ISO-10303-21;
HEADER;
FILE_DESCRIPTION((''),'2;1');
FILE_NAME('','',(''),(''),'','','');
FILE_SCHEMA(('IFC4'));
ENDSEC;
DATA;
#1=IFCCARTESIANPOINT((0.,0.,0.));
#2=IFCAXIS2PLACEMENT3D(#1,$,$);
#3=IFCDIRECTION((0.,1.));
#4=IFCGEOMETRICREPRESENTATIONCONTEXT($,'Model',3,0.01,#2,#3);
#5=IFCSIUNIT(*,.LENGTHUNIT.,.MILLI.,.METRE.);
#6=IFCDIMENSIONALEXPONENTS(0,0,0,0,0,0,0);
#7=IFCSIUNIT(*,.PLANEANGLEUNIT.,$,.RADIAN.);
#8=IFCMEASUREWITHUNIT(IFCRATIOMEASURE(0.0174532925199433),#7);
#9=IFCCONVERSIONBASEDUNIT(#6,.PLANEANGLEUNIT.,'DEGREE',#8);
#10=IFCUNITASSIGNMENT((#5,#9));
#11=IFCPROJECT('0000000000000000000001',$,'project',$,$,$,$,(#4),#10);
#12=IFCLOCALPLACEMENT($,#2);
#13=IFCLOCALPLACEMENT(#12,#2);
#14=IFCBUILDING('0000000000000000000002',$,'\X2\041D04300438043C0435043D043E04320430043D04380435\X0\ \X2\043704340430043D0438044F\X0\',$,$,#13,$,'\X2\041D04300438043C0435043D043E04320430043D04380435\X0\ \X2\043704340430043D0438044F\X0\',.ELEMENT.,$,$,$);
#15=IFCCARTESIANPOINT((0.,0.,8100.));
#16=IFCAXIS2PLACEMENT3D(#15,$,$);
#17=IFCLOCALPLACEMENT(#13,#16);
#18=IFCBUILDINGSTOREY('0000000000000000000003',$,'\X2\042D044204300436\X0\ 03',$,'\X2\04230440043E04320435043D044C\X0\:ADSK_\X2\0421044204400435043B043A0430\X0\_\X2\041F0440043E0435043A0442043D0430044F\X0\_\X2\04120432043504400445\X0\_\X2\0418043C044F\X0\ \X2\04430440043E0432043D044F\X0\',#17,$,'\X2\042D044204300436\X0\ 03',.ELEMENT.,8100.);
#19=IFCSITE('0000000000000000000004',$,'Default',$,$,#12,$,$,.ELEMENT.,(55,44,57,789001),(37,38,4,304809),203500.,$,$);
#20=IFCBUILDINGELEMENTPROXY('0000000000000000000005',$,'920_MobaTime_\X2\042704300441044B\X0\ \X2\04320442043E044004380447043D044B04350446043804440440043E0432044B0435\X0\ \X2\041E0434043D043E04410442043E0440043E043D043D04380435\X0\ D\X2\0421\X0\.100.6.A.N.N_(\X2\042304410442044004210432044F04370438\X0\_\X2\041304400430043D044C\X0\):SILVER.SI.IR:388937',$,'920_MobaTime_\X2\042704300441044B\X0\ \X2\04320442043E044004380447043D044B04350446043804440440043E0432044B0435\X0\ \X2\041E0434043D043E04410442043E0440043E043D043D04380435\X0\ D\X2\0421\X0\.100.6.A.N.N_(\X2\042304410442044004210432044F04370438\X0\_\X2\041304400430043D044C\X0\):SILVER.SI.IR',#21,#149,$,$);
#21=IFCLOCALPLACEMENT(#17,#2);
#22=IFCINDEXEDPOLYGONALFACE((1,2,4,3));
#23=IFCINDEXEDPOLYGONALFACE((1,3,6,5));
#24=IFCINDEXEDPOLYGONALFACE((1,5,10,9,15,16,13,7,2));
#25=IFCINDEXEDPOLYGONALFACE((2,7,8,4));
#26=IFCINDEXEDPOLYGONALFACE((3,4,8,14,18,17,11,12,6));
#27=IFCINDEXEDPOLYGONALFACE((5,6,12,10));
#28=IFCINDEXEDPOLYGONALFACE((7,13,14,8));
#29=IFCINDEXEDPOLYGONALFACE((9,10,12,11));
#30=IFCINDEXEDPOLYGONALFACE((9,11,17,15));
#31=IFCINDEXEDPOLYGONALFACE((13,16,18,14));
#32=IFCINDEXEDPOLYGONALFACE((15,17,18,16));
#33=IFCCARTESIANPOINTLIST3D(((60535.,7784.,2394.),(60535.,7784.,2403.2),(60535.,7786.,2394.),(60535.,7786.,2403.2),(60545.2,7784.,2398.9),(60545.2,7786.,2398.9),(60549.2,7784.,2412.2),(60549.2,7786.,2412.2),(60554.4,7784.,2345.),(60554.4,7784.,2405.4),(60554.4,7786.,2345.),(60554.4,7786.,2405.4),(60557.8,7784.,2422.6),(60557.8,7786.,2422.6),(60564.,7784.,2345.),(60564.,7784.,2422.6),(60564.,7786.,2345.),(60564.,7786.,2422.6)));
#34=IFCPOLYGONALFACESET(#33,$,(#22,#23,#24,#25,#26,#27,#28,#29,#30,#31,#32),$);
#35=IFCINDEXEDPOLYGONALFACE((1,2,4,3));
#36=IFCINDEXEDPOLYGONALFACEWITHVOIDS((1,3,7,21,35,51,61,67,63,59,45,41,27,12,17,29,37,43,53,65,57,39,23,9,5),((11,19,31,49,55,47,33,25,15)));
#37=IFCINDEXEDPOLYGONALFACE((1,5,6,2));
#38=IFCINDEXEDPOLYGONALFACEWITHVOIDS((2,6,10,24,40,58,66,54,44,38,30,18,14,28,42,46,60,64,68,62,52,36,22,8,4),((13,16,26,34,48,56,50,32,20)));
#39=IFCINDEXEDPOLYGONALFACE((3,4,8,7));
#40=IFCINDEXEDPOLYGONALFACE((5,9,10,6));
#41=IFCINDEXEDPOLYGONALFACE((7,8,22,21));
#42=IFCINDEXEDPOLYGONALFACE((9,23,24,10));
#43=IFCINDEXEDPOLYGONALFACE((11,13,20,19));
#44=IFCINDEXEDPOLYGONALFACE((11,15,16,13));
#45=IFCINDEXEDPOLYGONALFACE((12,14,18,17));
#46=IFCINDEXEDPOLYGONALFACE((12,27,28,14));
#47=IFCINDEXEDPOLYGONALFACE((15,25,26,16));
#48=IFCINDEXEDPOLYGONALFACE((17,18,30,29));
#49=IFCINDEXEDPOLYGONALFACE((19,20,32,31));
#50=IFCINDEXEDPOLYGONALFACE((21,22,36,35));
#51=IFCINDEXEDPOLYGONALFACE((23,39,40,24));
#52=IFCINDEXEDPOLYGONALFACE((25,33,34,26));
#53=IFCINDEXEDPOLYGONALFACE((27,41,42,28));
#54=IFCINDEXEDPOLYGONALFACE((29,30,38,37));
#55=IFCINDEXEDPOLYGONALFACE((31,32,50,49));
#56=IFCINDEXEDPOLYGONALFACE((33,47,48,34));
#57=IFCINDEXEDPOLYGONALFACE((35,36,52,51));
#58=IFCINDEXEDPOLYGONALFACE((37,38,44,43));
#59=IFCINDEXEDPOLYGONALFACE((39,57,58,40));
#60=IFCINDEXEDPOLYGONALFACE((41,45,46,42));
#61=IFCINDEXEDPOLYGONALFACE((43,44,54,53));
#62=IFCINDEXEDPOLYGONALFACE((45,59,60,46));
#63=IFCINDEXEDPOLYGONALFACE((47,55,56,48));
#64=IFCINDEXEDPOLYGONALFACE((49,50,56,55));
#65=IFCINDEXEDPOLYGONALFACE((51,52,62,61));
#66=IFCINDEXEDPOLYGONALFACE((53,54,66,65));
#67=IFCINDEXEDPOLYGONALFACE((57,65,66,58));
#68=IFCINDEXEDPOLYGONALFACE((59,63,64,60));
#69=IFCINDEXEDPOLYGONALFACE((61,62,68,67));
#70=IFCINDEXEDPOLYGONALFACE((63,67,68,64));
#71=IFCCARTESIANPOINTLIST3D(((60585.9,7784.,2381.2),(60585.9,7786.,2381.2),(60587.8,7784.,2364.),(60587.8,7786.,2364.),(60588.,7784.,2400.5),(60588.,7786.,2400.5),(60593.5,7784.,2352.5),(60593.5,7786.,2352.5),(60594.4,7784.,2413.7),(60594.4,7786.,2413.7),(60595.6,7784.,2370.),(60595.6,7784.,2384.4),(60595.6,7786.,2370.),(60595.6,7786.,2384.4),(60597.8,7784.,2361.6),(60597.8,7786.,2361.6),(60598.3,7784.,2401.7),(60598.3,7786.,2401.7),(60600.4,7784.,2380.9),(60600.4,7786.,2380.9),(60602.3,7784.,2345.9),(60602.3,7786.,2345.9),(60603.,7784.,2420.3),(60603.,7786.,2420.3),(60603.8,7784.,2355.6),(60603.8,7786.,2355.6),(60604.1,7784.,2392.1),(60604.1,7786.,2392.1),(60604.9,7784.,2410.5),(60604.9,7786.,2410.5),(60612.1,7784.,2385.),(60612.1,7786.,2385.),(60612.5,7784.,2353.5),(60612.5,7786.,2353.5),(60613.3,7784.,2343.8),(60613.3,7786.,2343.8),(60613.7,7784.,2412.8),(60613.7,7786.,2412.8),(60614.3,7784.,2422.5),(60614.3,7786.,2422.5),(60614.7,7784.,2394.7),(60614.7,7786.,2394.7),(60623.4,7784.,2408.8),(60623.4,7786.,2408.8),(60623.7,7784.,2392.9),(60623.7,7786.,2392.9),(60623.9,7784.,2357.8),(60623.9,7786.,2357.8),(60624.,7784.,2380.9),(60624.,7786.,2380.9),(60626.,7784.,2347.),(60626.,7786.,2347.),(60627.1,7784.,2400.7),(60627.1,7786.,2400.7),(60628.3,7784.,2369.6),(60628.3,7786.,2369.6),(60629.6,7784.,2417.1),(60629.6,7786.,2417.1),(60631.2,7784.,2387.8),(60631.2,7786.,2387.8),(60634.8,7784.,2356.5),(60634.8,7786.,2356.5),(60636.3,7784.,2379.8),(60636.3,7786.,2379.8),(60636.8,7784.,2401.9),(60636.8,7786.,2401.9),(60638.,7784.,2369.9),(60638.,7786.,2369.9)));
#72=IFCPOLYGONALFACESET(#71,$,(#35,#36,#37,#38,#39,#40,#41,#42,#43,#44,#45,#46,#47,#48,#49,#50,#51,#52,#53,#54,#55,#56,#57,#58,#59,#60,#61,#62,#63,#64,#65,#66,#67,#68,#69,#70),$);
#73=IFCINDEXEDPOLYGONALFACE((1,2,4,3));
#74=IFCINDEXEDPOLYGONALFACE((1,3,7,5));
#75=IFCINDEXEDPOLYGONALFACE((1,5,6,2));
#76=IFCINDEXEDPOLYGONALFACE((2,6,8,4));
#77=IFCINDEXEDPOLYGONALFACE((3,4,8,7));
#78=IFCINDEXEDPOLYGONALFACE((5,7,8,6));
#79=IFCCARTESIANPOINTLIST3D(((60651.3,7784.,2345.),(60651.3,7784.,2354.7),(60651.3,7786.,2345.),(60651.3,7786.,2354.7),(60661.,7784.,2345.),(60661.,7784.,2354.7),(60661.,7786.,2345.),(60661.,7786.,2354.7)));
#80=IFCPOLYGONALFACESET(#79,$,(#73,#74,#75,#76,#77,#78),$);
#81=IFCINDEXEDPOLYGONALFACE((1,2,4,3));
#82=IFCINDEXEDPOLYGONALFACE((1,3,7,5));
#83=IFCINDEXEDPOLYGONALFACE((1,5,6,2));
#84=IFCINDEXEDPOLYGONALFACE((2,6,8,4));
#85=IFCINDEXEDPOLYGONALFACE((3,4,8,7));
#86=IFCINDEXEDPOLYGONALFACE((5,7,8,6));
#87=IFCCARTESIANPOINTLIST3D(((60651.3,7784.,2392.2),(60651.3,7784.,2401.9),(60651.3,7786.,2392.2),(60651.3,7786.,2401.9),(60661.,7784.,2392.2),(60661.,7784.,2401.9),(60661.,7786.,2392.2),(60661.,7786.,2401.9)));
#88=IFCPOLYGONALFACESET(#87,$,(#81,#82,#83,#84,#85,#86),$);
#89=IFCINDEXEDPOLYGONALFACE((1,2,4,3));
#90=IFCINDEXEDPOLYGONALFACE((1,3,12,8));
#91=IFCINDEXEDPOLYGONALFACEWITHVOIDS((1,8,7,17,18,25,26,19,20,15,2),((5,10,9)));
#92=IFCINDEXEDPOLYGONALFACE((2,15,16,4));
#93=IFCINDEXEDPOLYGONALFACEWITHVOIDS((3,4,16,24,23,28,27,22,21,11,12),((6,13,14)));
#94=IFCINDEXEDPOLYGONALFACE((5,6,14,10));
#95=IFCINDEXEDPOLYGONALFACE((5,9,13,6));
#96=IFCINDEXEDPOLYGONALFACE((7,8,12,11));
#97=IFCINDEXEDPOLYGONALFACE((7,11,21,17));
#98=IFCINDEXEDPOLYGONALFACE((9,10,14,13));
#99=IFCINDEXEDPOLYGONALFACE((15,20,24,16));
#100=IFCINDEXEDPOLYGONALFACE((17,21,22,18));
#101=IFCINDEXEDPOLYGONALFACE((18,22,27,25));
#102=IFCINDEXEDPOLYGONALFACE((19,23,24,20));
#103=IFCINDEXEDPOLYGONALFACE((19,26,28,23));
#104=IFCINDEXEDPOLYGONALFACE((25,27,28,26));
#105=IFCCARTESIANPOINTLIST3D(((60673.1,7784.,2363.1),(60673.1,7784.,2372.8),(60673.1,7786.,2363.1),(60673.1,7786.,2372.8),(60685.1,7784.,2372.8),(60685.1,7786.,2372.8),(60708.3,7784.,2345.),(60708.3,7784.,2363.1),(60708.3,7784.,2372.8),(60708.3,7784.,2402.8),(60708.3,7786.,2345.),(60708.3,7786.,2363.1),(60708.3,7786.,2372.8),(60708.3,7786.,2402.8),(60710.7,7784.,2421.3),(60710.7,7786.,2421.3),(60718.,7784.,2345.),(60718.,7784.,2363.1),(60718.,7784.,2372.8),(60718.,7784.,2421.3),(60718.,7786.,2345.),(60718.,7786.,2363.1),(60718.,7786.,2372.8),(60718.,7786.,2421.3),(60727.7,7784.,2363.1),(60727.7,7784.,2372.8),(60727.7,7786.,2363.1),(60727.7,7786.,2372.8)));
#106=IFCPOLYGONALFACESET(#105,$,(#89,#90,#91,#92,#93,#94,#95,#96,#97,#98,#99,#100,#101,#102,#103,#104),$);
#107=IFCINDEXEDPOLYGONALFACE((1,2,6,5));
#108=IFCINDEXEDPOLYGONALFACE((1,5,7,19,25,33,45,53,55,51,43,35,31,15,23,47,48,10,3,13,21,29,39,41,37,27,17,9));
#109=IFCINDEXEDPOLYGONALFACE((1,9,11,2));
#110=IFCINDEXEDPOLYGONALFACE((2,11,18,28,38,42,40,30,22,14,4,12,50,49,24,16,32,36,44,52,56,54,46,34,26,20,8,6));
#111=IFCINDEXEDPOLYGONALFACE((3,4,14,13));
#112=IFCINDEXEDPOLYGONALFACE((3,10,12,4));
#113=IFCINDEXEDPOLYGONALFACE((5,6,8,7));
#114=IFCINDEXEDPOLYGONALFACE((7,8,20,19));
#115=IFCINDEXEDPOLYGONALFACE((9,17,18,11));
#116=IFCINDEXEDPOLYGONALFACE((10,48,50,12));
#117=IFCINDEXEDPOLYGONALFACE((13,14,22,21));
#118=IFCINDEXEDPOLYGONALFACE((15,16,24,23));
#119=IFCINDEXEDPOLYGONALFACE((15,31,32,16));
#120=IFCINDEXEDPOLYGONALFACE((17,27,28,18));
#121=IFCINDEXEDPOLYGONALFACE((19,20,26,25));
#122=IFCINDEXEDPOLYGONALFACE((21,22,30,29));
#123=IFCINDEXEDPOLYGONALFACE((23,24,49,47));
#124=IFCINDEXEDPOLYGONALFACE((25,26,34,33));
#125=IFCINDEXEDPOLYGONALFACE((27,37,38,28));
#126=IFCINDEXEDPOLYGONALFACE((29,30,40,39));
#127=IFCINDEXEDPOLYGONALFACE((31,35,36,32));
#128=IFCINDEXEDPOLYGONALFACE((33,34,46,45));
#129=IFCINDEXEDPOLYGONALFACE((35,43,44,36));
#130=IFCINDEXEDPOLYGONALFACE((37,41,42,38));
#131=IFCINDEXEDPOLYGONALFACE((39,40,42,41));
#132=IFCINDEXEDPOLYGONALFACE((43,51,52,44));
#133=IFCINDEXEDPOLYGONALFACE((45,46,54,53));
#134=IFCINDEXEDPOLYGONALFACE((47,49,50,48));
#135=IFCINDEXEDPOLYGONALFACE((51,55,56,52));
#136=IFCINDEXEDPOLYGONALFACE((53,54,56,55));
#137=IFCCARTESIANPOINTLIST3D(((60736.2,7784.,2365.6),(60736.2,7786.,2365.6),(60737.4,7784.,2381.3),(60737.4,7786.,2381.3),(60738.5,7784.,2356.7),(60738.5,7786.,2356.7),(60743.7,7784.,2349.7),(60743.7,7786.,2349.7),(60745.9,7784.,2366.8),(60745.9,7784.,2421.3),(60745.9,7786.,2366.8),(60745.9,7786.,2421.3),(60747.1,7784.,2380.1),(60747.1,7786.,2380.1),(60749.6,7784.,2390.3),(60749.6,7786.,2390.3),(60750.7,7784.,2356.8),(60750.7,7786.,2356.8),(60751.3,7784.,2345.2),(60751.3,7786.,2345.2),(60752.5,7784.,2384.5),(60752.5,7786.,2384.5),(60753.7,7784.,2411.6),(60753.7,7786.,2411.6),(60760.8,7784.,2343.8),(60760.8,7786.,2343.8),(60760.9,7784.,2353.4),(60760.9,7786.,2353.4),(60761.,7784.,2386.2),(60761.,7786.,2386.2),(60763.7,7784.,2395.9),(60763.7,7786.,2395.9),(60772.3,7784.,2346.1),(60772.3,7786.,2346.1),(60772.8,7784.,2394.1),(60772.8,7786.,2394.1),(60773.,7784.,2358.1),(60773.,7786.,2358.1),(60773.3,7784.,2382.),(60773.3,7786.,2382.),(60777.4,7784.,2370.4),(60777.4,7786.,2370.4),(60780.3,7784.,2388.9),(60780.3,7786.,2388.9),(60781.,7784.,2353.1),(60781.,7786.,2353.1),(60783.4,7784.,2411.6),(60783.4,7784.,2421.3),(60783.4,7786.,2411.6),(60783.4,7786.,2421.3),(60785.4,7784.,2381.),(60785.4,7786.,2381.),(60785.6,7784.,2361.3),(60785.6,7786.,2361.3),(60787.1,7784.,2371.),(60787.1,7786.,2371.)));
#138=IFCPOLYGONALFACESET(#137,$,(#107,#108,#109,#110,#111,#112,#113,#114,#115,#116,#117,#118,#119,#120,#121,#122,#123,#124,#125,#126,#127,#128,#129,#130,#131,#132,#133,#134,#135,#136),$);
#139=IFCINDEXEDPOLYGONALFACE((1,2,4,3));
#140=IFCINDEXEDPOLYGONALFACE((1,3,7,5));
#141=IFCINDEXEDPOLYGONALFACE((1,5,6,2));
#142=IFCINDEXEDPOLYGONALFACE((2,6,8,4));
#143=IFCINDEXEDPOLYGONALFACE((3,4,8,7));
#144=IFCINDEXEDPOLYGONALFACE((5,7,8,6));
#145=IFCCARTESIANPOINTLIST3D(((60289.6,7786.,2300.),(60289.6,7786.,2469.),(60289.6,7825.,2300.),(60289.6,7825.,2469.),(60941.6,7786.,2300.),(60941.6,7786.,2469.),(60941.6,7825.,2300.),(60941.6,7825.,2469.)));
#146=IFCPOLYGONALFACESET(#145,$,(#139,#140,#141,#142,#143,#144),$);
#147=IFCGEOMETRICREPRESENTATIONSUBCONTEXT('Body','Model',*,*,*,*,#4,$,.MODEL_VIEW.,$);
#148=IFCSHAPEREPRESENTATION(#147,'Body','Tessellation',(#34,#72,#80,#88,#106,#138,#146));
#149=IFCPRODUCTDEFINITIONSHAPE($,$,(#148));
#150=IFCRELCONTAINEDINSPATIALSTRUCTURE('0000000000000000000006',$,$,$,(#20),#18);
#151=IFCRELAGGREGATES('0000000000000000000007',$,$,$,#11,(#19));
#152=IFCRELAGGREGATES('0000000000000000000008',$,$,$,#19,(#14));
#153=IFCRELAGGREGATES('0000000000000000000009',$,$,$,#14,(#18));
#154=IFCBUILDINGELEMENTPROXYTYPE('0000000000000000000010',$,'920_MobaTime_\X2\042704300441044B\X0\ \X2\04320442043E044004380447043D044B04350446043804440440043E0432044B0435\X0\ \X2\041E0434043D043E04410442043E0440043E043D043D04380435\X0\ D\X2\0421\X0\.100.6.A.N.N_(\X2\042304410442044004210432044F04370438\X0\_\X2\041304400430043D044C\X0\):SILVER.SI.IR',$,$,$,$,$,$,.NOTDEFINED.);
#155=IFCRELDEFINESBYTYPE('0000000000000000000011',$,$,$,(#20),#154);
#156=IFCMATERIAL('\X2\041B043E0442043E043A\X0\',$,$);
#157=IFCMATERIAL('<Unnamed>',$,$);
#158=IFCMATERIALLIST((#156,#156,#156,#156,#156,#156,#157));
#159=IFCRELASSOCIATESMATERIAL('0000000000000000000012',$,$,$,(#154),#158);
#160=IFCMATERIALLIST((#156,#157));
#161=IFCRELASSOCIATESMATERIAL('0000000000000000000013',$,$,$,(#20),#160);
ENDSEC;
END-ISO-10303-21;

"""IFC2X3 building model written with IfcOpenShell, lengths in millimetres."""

from ifc_helpers import new_model, entity, si_unit, converted_unit, direction, frame, origin, origin_2d_with_axis, place, context, subcontext, project, spatial, polyline, rectangle, outline, extrude, source, transform, mapped, material, material_list, type_object, type_shapes, element, save


model = new_model("IFC2X3")

# Units and contexts
model_context = context("Model", 3, precision=0.01, world=origin(), true_north=direction((0.0, 1.0)))
body_context = subcontext(model_context, "Body", "Model", "MODEL_VIEW")
ifc_project = project(units=[si_unit("LENGTHUNIT", "METRE", prefix="MILLI"), converted_unit("PLANEANGLEUNIT", "DEGREE", entity("IfcRatioMeasure", 0.0174532925199433), si_unit("PLANEANGLEUNIT", "RADIAN"), dimensions=[0, 0, 0, 0, 0, 0, 0])], contexts=[model_context])

# Site, building, storey
site_placement = place(None, origin())
site = spatial("IfcSite", under=ifc_project, at=site_placement, Name="Default", CompositionType="ELEMENT", RefLatitude=(55, 44, 57, 789001), RefLongitude=(37, 38, 4, 304809), RefElevation=203500.0)
building_placement = place(site_placement, origin())
building = spatial("IfcBuilding", under=site, at=building_placement, Name="Наименование здания", LongName="Наименование здания", CompositionType="ELEMENT")
storey_placement = place(building_placement, frame((0.0, 0.0, 8100.0)))
storey = spatial("IfcBuildingStorey", under=building, at=storey_placement, Name="Этаж 03", ObjectType="Уровень:ADSK_Стрелка_Проектная_Вверх_Имя уровня", LongName="Этаж 03", CompositionType="ELEMENT", Elevation=8100.0)

# Building element proxy
ifc_material_1 = material(Name="Лоток")
ifc_material_2 = material(Name="<Unnamed>")
ifc_material_list_1 = material_list([ifc_material_1, ifc_material_1, ifc_material_1, ifc_material_1, ifc_material_1, ifc_material_1, ifc_material_2])
building_element_proxy_type = type_object("IfcBuildingElementProxyType", Name="920_MobaTime_Часы вторичныецифровые Односторонние DС.100.6.A.N.N_(УстрСвязи_Грань):SILVER.SI.IR", PredefinedType="NOTDEFINED", material=ifc_material_list_1)
shared_shape = source(origin(), body_context, "Body", "SweptSolid", [
    extrude(outline(polyline([(-49.3, -13.1), (28.2, -13.1), (28.2, -6.8), (17.9, 1.8), (8.8, 16.0), (-0.3, 16.0), (4.6, 5.8), (11.1, -3.4), (-49.3, -3.4), (-49.3, -13.1)])), frame((-64.6, 9.8, 39.0), z_axis=(0.0, 0.0, 1.0), x_axis=(0.0, 1.0, 0.0)), (0.0, 0.0, 1.0), 2.0),
    extrude(outline(polyline([(2.2, -27.6), (19.0, -27.6), (30.5, -16.1), (33.3, -4.9), (31.0, 5.8), (21.8, 17.2), (5.2, 27.3), (-11.1, 33.0), (-24.0, 32.7), (-33.6, 27.6), (-40.3, 18.6), (-42.8, 5.7), (-38.0, -6.3), (-27.2, -14.9), (-17.5, -17.7), (-8.2, -16.4), (-0.3, -11.9), (5.1, -4.5), (7.3, 6.2), (4.0, 17.2), (18.4, 7.3), (23.6, -2.4), (22.0, -11.4), (14.2, -18.4), (5.3, -18.3), (2.2, -27.6)]), holes=[polyline([(-9.0, 23.3), (-1.3, 14.3), (-2.5, 2.0), (-11.4, -7.0), (-23.4, -6.0), (-32.2, 2.9), (-31.2, 15.1), (-25.6, 22.1), (-17.5, 24.9), (-9.0, 23.3)])]), frame((-2.7, 3.6, 39.0), z_axis=(0.0, 0.0, 1.0), x_axis=(-0.427649, 0.903945, 0.0)), (0.0, 0.0, 1.0), 2.0),
    extrude(rectangle(XDim=9.7, YDim=9.7, at=origin_2d_with_axis()), frame((40.6, -34.7, 39.0)), (0.0, 0.0, 1.0), 2.0),
    extrude(rectangle(XDim=9.7, YDim=9.7, at=origin_2d_with_axis()), frame((40.6, 12.6, 39.0)), (0.0, 0.0, 1.0), 2.0),
    extrude(outline(polyline([(-0.9, -28.1), (8.8, -28.1), (8.8, -9.9), (18.5, -9.9), (18.5, -0.2), (8.8, -0.2), (8.8, 48.3), (1.5, 48.3), (-36.0, -0.2), (-36.0, -9.9), (-0.9, -9.9), (-0.9, -28.1)]), holes=[polyline([(-0.9, -0.2), (-24.1, -0.2), (-0.9, 29.7), (-0.9, -0.2)])]), frame((93.6, -11.4, 39.0)), (0.0, 0.0, 1.0), 2.0),
    extrude(outline(polyline([(3.3, -28.3), (12.5, -28.3), (20.5, -25.0), (26.8, -18.9), (30.7, -10.0), (31.4, 1.6), (26.9, 11.8), (20.1, 18.4), (11.1, 22.3), (1.0, 23.3), (-7.9, 20.4), (-14.9, 14.5), (-18.9, 6.2), (-17.1, -9.0), (-36.7, 0.5), (-29.1, 29.2), (-38.5, 31.7), (-48.1, -4.6), (-11.6, -23.1), (-8.0, -14.0), (-10.8, -7.6), (-10.2, 1.1), (-3.0, 11.8), (9.2, 12.8), (20.0, 5.5), (21.4, -7.5), (15.5, -16.4), (4.6, -18.6), (3.3, -28.3)])), frame((147.1, -8.5, 39.0), z_axis=(0.0, 0.0, 1.0), x_axis=(0.256974, -0.966418, 0.0)), (0.0, 0.0, 1.0), 2.0),
    extrude(rectangle(XDim=652.0, YDim=169.0, at=origin_2d_with_axis()), frame((0.0, 0.0, 0.0), z_axis=(0.0, 0.0, 1.0), x_axis=(-1.0, 0.0, 0.0)), (0.0, 0.0, 1.0), 39.0),
])
type_shapes(building_element_proxy_type, [shared_shape])
ifc_material_list_2 = material_list([ifc_material_1, ifc_material_2])
for number, where, z_axis, x_axis, name in (
    (1, (60615.6, 7825.0, 2384.5), (0.0, -1.0, 0.0), (1.0, 0.0, 0.0), "920_MobaTime_Часы вторичныецифровые Односторонние DС.100.6.A.N.N_(УстрСвязи_Грань):SILVER.SI.IR:388937"),
):
    element("IfcBuildingElementProxy", number, at=place(storey_placement, frame(where, z_axis=z_axis, x_axis=x_axis)), inside=storey, type_object=building_element_proxy_type, material=ifc_material_list_2, Name=name, ObjectType="920_MobaTime_Часы вторичныецифровые Односторонние DС.100.6.A.N.N_(УстрСвязи_Грань):SILVER.SI.IR", context=body_context, shape_type="MappedRepresentation", body=[
        mapped(shared_shape, transform((0.0, 0.0, 0.0), scale=1.0)),
    ])

save(model, "model.ifc")
